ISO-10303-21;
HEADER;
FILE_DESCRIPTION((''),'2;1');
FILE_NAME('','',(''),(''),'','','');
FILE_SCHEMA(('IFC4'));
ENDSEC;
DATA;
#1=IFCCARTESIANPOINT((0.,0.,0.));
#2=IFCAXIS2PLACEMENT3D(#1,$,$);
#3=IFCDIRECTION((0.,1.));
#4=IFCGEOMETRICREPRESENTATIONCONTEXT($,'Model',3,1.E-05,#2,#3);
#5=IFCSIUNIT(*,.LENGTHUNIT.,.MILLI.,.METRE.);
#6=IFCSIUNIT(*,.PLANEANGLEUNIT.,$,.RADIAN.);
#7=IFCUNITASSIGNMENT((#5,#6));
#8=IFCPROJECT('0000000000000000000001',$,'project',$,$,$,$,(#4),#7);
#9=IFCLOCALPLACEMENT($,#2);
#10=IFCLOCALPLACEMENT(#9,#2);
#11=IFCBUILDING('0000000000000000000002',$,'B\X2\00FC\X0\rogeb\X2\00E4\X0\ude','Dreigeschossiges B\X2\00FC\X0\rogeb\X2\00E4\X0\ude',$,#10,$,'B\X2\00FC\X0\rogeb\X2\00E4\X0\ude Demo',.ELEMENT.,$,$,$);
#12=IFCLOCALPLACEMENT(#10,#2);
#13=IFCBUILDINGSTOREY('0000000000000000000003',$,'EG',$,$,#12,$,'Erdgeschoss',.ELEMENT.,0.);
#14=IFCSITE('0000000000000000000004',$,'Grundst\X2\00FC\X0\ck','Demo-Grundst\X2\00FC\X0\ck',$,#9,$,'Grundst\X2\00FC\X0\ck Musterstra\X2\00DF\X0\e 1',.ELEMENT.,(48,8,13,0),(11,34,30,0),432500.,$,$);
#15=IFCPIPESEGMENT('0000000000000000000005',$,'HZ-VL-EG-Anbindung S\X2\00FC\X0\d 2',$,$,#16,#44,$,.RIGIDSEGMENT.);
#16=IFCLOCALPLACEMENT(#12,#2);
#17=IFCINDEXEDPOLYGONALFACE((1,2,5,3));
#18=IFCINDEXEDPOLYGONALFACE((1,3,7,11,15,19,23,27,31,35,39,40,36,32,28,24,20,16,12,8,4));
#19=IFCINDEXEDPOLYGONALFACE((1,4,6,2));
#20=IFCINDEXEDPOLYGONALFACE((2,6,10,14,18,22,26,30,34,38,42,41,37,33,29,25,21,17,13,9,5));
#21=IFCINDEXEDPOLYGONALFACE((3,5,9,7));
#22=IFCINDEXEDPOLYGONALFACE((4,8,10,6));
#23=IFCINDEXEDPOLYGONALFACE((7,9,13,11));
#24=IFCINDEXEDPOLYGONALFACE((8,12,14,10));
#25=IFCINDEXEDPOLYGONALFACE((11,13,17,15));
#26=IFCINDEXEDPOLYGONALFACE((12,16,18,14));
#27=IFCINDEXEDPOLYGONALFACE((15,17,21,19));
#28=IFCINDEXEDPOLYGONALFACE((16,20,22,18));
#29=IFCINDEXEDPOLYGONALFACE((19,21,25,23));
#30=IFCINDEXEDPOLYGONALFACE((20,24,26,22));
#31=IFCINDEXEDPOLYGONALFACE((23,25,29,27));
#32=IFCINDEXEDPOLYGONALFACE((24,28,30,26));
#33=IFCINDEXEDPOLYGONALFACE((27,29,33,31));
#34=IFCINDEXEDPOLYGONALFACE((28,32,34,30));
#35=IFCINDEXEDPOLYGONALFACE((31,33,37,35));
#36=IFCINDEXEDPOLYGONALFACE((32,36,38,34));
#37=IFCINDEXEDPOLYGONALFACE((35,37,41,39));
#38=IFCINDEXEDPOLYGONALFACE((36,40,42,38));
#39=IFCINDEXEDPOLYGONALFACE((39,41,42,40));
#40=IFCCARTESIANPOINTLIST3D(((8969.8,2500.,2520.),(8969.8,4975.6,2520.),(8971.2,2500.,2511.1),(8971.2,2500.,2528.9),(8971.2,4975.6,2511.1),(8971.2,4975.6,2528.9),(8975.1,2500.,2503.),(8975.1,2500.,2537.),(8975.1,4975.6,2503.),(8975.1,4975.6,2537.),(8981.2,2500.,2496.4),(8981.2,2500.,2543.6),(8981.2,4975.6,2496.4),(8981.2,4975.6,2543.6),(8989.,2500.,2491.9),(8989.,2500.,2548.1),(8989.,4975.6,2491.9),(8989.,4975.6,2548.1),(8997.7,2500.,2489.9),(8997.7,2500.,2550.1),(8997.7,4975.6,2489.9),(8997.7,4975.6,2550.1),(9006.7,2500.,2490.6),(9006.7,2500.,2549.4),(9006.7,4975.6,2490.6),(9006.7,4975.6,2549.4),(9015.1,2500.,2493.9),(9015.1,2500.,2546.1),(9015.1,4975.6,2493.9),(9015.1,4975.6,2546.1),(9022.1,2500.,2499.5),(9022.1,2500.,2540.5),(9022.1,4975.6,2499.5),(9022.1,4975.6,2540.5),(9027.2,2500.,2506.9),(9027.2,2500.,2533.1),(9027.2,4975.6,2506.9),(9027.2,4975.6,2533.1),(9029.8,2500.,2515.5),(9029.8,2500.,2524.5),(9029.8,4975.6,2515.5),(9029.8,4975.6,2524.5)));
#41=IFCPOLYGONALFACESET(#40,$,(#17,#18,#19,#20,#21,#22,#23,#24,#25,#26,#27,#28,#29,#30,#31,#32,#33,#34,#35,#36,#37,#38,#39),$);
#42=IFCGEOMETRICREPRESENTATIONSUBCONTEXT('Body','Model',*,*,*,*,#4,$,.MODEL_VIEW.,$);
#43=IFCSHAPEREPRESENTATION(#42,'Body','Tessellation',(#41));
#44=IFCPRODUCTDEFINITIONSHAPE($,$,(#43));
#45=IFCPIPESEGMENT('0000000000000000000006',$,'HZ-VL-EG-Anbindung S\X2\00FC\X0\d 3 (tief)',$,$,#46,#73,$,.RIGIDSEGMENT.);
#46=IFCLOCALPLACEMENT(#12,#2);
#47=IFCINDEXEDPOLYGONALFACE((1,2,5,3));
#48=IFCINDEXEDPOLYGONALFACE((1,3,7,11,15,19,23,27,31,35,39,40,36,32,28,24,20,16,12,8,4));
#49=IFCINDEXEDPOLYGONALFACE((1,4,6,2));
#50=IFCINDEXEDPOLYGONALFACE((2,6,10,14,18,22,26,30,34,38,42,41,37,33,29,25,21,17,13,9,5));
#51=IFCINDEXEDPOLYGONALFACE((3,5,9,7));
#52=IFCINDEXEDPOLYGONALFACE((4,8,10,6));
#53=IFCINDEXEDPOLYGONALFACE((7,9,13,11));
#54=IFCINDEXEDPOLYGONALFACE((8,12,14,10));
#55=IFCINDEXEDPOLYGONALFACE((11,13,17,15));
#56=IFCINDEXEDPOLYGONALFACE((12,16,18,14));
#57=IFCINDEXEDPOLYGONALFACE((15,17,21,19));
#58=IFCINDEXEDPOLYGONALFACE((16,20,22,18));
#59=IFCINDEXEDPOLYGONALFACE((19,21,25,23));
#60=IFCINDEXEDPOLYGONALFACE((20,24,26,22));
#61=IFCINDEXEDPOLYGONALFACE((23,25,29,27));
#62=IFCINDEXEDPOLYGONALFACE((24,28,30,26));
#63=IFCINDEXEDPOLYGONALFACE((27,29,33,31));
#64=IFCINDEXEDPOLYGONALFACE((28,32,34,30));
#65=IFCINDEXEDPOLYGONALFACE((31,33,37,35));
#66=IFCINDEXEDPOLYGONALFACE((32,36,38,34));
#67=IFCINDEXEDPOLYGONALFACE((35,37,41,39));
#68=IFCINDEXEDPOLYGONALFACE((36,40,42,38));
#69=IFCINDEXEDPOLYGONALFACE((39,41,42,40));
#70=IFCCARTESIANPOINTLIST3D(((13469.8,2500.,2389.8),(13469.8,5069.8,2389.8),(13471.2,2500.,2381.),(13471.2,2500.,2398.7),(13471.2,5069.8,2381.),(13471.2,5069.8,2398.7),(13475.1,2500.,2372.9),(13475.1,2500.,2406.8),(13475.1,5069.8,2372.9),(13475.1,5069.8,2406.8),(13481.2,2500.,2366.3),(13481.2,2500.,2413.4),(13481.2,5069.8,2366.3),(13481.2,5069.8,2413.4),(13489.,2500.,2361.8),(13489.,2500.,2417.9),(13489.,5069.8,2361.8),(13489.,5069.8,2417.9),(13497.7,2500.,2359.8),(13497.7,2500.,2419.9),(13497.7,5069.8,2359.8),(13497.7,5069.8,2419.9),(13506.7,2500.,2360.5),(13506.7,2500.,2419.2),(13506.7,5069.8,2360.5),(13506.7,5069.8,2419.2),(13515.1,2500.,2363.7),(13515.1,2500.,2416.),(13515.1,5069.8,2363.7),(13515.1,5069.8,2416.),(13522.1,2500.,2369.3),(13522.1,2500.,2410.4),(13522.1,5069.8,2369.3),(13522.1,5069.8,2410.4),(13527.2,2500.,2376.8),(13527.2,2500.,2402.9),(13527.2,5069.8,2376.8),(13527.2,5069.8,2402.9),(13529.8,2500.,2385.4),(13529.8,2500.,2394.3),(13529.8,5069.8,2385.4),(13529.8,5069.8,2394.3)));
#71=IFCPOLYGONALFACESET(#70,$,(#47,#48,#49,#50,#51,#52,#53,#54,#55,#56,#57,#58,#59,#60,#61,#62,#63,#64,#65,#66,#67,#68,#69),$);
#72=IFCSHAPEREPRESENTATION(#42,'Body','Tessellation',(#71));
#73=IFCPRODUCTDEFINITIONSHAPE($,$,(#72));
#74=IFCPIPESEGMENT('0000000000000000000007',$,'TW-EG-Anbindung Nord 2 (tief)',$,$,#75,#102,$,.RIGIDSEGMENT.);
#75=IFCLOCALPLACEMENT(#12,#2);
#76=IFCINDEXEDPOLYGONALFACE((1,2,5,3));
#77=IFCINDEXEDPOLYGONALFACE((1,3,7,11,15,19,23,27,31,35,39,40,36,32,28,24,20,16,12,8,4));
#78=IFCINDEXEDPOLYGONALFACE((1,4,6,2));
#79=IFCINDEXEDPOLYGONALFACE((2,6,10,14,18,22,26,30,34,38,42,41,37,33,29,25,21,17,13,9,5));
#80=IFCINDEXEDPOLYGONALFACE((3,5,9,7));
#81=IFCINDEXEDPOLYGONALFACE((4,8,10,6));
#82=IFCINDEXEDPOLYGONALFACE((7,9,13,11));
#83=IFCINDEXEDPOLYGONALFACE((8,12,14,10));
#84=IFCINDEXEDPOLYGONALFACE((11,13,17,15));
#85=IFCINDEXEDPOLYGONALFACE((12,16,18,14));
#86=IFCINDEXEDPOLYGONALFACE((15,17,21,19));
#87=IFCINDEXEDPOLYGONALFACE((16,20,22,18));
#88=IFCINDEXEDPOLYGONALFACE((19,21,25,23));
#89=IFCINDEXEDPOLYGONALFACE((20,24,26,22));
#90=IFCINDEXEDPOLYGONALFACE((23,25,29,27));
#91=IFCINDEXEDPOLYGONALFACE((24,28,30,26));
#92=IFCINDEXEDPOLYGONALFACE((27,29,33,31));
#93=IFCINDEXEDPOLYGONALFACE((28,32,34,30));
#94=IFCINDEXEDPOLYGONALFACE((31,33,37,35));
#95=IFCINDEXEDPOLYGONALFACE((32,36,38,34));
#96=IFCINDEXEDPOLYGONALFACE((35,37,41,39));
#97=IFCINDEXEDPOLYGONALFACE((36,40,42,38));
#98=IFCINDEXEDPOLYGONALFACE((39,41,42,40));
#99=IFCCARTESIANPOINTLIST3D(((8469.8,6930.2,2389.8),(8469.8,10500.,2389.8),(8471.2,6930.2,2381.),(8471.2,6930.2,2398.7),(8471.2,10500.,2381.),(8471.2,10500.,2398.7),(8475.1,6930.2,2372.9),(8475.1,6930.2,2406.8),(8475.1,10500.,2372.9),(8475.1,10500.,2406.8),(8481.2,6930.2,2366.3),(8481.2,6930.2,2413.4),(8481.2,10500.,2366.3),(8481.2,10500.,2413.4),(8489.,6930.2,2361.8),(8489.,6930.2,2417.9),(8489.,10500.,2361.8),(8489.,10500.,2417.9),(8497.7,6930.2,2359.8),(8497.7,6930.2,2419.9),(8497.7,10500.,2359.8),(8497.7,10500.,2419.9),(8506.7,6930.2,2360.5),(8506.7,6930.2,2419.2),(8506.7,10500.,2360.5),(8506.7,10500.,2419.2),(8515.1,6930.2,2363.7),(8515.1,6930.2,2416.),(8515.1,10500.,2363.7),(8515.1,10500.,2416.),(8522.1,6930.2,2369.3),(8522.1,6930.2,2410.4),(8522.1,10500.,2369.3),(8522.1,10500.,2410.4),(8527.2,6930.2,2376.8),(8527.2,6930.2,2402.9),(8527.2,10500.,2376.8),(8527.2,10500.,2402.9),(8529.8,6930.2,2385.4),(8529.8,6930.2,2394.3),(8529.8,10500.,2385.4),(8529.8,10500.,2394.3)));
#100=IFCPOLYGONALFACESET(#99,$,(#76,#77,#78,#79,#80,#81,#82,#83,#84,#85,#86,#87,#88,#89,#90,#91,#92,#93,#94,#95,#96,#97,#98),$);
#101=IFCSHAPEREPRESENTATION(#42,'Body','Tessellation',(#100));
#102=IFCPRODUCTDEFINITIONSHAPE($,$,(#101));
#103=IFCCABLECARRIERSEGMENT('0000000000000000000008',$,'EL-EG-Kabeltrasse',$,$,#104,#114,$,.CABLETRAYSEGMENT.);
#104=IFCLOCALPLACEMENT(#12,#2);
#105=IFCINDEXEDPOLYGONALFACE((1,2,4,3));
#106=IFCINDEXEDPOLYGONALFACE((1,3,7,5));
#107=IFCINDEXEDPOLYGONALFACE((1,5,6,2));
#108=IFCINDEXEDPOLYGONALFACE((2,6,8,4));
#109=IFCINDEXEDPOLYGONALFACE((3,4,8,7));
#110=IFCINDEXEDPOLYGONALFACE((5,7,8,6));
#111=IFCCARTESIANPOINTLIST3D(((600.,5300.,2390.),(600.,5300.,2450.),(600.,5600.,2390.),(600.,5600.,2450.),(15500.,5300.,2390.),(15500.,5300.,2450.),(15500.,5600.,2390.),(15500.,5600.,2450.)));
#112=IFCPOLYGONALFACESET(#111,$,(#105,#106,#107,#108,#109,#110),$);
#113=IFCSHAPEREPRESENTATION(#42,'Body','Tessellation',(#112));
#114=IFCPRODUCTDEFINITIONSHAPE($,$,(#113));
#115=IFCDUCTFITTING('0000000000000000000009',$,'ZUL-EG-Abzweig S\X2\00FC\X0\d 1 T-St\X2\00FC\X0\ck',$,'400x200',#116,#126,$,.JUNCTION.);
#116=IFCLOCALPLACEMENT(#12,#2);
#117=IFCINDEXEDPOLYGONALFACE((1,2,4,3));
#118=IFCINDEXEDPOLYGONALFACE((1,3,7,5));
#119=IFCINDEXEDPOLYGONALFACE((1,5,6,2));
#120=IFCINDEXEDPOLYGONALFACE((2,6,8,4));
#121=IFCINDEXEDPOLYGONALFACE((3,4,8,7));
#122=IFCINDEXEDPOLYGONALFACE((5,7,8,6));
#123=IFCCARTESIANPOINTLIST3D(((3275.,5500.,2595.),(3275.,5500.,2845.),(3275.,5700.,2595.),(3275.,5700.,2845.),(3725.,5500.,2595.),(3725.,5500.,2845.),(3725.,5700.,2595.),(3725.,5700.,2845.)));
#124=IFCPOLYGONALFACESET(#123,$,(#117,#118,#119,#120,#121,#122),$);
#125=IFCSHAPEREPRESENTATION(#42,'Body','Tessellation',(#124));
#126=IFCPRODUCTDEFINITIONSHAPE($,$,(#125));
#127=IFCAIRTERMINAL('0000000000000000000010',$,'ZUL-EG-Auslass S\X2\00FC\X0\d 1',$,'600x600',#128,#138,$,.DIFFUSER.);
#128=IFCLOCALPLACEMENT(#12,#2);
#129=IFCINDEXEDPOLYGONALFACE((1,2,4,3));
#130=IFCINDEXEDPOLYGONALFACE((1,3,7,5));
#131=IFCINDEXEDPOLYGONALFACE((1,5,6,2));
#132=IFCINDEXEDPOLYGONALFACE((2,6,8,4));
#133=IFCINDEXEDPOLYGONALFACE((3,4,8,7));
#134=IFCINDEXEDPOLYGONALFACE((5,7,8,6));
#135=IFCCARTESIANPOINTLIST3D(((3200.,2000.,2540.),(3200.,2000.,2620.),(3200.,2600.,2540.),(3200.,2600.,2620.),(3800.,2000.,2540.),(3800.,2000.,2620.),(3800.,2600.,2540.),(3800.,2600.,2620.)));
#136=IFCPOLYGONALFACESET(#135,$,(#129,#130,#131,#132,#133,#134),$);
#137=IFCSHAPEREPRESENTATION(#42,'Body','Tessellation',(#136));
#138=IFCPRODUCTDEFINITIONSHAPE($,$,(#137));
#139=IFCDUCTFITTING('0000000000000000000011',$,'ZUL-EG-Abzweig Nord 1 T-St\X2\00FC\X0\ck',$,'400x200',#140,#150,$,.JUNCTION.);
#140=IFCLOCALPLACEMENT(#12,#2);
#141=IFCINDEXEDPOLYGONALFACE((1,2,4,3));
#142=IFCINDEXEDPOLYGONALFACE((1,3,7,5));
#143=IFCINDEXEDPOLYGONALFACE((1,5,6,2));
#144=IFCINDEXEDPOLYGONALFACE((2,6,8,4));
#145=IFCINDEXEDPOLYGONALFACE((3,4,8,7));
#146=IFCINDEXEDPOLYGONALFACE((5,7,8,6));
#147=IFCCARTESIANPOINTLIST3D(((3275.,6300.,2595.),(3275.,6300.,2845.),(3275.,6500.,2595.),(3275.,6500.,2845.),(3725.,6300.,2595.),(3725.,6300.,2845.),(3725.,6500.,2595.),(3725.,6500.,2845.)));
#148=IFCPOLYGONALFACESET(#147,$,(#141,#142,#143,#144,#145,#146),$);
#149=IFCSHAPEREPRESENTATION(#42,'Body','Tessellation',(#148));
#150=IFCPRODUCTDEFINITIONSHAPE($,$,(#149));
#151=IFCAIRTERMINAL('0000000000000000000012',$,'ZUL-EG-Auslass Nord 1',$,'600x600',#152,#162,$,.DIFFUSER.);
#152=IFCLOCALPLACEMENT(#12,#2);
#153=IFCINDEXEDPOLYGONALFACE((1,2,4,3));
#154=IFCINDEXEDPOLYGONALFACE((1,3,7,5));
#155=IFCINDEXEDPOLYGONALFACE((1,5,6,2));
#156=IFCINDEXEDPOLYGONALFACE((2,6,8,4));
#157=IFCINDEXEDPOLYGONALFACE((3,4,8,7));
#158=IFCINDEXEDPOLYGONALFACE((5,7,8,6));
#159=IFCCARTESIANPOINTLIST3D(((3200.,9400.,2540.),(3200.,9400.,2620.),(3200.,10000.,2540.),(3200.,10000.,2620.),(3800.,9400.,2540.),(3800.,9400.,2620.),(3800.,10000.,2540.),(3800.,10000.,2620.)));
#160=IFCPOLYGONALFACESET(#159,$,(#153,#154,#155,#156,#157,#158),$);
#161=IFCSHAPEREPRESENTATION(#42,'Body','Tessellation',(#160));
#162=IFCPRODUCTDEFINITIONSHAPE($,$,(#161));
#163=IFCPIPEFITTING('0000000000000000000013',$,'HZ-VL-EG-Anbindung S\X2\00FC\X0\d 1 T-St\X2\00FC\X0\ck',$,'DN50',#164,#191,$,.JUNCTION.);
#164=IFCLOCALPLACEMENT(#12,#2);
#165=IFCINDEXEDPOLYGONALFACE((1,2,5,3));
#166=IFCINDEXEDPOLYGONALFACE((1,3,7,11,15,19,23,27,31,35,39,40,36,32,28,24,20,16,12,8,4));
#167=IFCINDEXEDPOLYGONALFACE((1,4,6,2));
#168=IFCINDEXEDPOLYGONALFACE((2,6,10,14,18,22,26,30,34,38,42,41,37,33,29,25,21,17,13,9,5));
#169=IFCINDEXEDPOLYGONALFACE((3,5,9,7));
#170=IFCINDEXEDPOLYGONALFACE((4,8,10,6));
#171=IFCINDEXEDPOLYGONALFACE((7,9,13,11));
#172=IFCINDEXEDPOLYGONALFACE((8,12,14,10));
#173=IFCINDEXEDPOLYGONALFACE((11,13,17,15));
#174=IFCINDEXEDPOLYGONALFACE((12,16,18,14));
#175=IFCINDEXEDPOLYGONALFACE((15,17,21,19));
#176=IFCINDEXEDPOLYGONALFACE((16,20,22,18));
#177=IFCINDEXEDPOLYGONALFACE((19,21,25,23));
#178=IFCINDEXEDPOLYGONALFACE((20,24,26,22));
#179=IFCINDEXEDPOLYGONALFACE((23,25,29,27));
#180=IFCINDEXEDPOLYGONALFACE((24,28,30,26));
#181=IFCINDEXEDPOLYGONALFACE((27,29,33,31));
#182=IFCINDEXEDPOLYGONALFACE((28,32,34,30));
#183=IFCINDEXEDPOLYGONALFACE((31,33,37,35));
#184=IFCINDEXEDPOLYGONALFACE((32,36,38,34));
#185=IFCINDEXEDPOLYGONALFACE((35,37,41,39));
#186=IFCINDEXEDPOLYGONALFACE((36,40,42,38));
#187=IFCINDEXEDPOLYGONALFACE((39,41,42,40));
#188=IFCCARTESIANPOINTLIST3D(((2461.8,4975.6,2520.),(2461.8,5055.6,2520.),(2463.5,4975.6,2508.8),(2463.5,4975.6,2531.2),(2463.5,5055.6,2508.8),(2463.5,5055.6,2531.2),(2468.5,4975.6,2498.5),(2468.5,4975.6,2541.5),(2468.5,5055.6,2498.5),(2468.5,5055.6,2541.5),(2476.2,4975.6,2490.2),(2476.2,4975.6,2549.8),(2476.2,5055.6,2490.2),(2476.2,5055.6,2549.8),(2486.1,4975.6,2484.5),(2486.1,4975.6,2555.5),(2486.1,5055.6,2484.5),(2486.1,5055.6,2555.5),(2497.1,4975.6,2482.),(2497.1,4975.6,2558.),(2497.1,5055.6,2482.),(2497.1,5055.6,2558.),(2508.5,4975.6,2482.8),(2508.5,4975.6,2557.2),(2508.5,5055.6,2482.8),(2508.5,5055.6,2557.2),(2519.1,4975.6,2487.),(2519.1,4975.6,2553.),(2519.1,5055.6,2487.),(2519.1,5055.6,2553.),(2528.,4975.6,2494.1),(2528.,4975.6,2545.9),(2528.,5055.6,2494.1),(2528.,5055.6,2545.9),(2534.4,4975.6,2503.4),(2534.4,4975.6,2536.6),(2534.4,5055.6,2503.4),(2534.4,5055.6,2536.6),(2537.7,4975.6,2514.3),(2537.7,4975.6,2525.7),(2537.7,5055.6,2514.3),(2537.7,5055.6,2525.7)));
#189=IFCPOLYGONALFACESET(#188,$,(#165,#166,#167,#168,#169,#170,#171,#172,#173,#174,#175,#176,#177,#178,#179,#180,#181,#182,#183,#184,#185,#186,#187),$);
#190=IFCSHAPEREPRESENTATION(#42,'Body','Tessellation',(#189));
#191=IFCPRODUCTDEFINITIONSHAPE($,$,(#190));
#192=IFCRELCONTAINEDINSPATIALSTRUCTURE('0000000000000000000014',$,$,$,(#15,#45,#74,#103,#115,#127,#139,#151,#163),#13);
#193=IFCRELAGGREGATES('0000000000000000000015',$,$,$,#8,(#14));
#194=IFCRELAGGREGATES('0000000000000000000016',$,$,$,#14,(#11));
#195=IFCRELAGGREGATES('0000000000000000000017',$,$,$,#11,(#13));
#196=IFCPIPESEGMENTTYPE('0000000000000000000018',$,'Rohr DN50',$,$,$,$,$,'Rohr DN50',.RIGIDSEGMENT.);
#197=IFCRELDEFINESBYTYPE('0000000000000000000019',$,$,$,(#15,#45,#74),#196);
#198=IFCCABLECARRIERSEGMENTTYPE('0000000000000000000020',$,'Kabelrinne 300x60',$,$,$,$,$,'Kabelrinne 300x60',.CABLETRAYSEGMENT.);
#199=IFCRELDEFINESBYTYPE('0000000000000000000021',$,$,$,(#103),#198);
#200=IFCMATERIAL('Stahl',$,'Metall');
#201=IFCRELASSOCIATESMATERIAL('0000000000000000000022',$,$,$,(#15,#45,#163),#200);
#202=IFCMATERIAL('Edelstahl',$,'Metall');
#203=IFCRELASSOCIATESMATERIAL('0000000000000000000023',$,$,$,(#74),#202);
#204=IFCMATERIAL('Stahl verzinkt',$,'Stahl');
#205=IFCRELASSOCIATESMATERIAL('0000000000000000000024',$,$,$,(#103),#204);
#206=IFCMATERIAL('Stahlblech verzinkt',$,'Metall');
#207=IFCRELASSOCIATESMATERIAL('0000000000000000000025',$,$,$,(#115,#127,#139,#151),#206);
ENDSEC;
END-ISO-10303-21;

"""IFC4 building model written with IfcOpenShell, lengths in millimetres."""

from ifc_helpers import new_model, si_unit, direction, frame, origin, origin_2d, place, context, subcontext, project, spatial, rectangle, circle, extrude, material, type_object, element, save


model = new_model("IFC4")

# Units and contexts
model_context = context("Model", 3, precision=1e-05, world=origin(), true_north=direction((0.0, 1.0)))
body_context = subcontext(model_context, "Body", "Model", "MODEL_VIEW")
ifc_project = project(units=[si_unit("LENGTHUNIT", "METRE", prefix="MILLI"), si_unit("PLANEANGLEUNIT", "RADIAN")], contexts=[model_context])

# Site, building, storey
site_placement = place(None, origin())
site = spatial("IfcSite", under=ifc_project, at=site_placement, Name="Grundstück", Description="Demo-Grundstück", LongName="Grundstück Musterstraße 1", CompositionType="ELEMENT", RefLatitude=(48, 8, 13, 0), RefLongitude=(11, 34, 30, 0), RefElevation=432500.0)
building_placement = place(site_placement, origin())
building = spatial("IfcBuilding", under=site, at=building_placement, Name="Bürogebäude", Description="Dreigeschossiges Bürogebäude", LongName="Bürogebäude Demo", CompositionType="ELEMENT")
storey_placement = place(building_placement, origin())
storey = spatial("IfcBuildingStorey", under=building, at=storey_placement, Name="EG", LongName="Erdgeschoss", CompositionType="ELEMENT", Elevation=0.0)

# Shared definitions
ifc_material_1 = material(Name="Stahlblech verzinkt", Category="Metall")

# Pipe segments
ifc_material_2 = material(Name="Stahl", Category="Metall")
ifc_material_3 = material(Name="Edelstahl", Category="Metall")
pipe_segment_type_1 = type_object("IfcPipeSegmentType", Name="Rohr DN50", ElementType="Rohr DN50", PredefinedType="RIGIDSEGMENT")
pipe_segment_1_placement = place(storey_placement, frame((9000.0, 2500.0, 2520.0)))
element("IfcPipeSegment", 1, at=pipe_segment_1_placement, inside=storey, type_object=pipe_segment_type_1, material=ifc_material_2, Name="HZ-VL-EG-Anbindung Süd 2", PredefinedType="RIGIDSEGMENT", context=body_context, shape_type="SweptSolid", body=[
    extrude(circle(Radius=30.1, at=origin_2d()), frame((0.0, 0.0, 0.0), z_axis=(0.0, 1.0, 0.0), x_axis=(-1.0, 0.0, 0.0)), (0.0, 0.0, 1.0), 2475.6),
])
pipe_segment_2_placement = place(storey_placement, frame((13500.0, 2500.0, 2389.8)))
element("IfcPipeSegment", 2, at=pipe_segment_2_placement, inside=storey, type_object=pipe_segment_type_1, material=ifc_material_2, Name="HZ-VL-EG-Anbindung Süd 3 (tief)", PredefinedType="RIGIDSEGMENT", context=body_context, shape_type="SweptSolid", body=[
    extrude(circle(Radius=30.1, at=origin_2d()), frame((0.0, 0.0, 0.0), z_axis=(0.0, 1.0, 0.0), x_axis=(-1.0, 0.0, 0.0)), (0.0, 0.0, 1.0), 2569.8),
])
pipe_segment_3_placement = place(storey_placement, frame((8500.0, 6930.1, 2389.8)))
element("IfcPipeSegment", 3, at=pipe_segment_3_placement, inside=storey, type_object=pipe_segment_type_1, material=ifc_material_3, Name="TW-EG-Anbindung Nord 2 (tief)", PredefinedType="RIGIDSEGMENT", context=body_context, shape_type="SweptSolid", body=[
    extrude(circle(Radius=30.1, at=origin_2d()), frame((0.0, 0.0, 0.0), z_axis=(0.0, 1.0, 0.0), x_axis=(-1.0, 0.0, 0.0)), (0.0, 0.0, 1.0), 3569.8),
])

# Cable carrier segment
ifc_material_4 = material(Name="Stahl verzinkt", Category="Stahl")
cable_carrier_segment_type = type_object("IfcCableCarrierSegmentType", Name="Kabelrinne 300x60", ElementType="Kabelrinne 300x60", PredefinedType="CABLETRAYSEGMENT")
cable_carrier_segment_placement = place(storey_placement, frame((600.0, 5450.0, 2420.0)))
element("IfcCableCarrierSegment", 4, at=cable_carrier_segment_placement, inside=storey, type_object=cable_carrier_segment_type, material=ifc_material_4, Name="EL-EG-Kabeltrasse", PredefinedType="CABLETRAYSEGMENT", context=body_context, shape_type="SweptSolid", body=[
    extrude(rectangle(XDim=300.0, YDim=60.0, at=origin_2d()), frame((0.0, 0.0, 0.0), z_axis=(1.0, 0.0, 0.0), x_axis=(0.0, 1.0, 0.0)), (0.0, 0.0, 1.0), 14900.0),
])

# Duct fitting
duct_fitting_1_placement = place(storey_placement, frame((3500.0, 5500.0, 2720.0)))
element("IfcDuctFitting", 5, at=duct_fitting_1_placement, inside=storey, material=ifc_material_1, Name="ZUL-EG-Abzweig Süd 1 T-Stück", ObjectType="400x200", PredefinedType="JUNCTION", context=body_context, shape_type="SweptSolid", body=[
    extrude(rectangle(XDim=450.0, YDim=250.0, at=origin_2d()), frame((0.0, 0.0, 0.0), z_axis=(0.0, 1.0, 0.0), x_axis=(-1.0, 0.0, 0.0)), (0.0, 0.0, 1.0), 200.0),
])

# Air terminal
air_terminal_1_placement = place(storey_placement, frame((3500.0, 2300.0, 2540.0)))
element("IfcAirTerminal", 6, at=air_terminal_1_placement, inside=storey, material=ifc_material_1, Name="ZUL-EG-Auslass Süd 1", ObjectType="600x600", PredefinedType="DIFFUSER", context=body_context, shape_type="SweptSolid", body=[
    extrude(rectangle(XDim=600.0, YDim=600.0, at=origin_2d()), origin(), (0.0, 0.0, 1.0), 80.0),
])

# Duct fitting
duct_fitting_2_placement = place(storey_placement, frame((3500.0, 6300.0, 2720.0)))
element("IfcDuctFitting", 7, at=duct_fitting_2_placement, inside=storey, material=ifc_material_1, Name="ZUL-EG-Abzweig Nord 1 T-Stück", ObjectType="400x200", PredefinedType="JUNCTION", context=body_context, shape_type="SweptSolid", body=[
    extrude(rectangle(XDim=450.0, YDim=250.0, at=origin_2d()), frame((0.0, 0.0, 0.0), z_axis=(0.0, 1.0, 0.0), x_axis=(-1.0, 0.0, 0.0)), (0.0, 0.0, 1.0), 200.0),
])

# Air terminal
air_terminal_2_placement = place(storey_placement, frame((3500.0, 9700.0, 2540.0)))
element("IfcAirTerminal", 8, at=air_terminal_2_placement, inside=storey, material=ifc_material_1, Name="ZUL-EG-Auslass Nord 1", ObjectType="600x600", PredefinedType="DIFFUSER", context=body_context, shape_type="SweptSolid", body=[
    extrude(rectangle(XDim=600.0, YDim=600.0, at=origin_2d()), origin(), (0.0, 0.0, 1.0), 80.0),
])

# Pipe fitting
pipe_fitting_1_placement = place(storey_placement, frame((2500.0, 4975.6, 2520.0)))
element("IfcPipeFitting", 9, at=pipe_fitting_1_placement, inside=storey, material=ifc_material_2, Name="HZ-VL-EG-Anbindung Süd 1 T-Stück", ObjectType="DN50", PredefinedType="JUNCTION", context=body_context, shape_type="SweptSolid", body=[
    extrude(circle(Radius=38.1, at=origin_2d()), frame((0.0, 0.0, 0.0), z_axis=(0.0, 1.0, 0.0), x_axis=(-1.0, 0.0, 0.0)), (0.0, 0.0, 1.0), 80.0),
])

save(model, "model.ifc")
